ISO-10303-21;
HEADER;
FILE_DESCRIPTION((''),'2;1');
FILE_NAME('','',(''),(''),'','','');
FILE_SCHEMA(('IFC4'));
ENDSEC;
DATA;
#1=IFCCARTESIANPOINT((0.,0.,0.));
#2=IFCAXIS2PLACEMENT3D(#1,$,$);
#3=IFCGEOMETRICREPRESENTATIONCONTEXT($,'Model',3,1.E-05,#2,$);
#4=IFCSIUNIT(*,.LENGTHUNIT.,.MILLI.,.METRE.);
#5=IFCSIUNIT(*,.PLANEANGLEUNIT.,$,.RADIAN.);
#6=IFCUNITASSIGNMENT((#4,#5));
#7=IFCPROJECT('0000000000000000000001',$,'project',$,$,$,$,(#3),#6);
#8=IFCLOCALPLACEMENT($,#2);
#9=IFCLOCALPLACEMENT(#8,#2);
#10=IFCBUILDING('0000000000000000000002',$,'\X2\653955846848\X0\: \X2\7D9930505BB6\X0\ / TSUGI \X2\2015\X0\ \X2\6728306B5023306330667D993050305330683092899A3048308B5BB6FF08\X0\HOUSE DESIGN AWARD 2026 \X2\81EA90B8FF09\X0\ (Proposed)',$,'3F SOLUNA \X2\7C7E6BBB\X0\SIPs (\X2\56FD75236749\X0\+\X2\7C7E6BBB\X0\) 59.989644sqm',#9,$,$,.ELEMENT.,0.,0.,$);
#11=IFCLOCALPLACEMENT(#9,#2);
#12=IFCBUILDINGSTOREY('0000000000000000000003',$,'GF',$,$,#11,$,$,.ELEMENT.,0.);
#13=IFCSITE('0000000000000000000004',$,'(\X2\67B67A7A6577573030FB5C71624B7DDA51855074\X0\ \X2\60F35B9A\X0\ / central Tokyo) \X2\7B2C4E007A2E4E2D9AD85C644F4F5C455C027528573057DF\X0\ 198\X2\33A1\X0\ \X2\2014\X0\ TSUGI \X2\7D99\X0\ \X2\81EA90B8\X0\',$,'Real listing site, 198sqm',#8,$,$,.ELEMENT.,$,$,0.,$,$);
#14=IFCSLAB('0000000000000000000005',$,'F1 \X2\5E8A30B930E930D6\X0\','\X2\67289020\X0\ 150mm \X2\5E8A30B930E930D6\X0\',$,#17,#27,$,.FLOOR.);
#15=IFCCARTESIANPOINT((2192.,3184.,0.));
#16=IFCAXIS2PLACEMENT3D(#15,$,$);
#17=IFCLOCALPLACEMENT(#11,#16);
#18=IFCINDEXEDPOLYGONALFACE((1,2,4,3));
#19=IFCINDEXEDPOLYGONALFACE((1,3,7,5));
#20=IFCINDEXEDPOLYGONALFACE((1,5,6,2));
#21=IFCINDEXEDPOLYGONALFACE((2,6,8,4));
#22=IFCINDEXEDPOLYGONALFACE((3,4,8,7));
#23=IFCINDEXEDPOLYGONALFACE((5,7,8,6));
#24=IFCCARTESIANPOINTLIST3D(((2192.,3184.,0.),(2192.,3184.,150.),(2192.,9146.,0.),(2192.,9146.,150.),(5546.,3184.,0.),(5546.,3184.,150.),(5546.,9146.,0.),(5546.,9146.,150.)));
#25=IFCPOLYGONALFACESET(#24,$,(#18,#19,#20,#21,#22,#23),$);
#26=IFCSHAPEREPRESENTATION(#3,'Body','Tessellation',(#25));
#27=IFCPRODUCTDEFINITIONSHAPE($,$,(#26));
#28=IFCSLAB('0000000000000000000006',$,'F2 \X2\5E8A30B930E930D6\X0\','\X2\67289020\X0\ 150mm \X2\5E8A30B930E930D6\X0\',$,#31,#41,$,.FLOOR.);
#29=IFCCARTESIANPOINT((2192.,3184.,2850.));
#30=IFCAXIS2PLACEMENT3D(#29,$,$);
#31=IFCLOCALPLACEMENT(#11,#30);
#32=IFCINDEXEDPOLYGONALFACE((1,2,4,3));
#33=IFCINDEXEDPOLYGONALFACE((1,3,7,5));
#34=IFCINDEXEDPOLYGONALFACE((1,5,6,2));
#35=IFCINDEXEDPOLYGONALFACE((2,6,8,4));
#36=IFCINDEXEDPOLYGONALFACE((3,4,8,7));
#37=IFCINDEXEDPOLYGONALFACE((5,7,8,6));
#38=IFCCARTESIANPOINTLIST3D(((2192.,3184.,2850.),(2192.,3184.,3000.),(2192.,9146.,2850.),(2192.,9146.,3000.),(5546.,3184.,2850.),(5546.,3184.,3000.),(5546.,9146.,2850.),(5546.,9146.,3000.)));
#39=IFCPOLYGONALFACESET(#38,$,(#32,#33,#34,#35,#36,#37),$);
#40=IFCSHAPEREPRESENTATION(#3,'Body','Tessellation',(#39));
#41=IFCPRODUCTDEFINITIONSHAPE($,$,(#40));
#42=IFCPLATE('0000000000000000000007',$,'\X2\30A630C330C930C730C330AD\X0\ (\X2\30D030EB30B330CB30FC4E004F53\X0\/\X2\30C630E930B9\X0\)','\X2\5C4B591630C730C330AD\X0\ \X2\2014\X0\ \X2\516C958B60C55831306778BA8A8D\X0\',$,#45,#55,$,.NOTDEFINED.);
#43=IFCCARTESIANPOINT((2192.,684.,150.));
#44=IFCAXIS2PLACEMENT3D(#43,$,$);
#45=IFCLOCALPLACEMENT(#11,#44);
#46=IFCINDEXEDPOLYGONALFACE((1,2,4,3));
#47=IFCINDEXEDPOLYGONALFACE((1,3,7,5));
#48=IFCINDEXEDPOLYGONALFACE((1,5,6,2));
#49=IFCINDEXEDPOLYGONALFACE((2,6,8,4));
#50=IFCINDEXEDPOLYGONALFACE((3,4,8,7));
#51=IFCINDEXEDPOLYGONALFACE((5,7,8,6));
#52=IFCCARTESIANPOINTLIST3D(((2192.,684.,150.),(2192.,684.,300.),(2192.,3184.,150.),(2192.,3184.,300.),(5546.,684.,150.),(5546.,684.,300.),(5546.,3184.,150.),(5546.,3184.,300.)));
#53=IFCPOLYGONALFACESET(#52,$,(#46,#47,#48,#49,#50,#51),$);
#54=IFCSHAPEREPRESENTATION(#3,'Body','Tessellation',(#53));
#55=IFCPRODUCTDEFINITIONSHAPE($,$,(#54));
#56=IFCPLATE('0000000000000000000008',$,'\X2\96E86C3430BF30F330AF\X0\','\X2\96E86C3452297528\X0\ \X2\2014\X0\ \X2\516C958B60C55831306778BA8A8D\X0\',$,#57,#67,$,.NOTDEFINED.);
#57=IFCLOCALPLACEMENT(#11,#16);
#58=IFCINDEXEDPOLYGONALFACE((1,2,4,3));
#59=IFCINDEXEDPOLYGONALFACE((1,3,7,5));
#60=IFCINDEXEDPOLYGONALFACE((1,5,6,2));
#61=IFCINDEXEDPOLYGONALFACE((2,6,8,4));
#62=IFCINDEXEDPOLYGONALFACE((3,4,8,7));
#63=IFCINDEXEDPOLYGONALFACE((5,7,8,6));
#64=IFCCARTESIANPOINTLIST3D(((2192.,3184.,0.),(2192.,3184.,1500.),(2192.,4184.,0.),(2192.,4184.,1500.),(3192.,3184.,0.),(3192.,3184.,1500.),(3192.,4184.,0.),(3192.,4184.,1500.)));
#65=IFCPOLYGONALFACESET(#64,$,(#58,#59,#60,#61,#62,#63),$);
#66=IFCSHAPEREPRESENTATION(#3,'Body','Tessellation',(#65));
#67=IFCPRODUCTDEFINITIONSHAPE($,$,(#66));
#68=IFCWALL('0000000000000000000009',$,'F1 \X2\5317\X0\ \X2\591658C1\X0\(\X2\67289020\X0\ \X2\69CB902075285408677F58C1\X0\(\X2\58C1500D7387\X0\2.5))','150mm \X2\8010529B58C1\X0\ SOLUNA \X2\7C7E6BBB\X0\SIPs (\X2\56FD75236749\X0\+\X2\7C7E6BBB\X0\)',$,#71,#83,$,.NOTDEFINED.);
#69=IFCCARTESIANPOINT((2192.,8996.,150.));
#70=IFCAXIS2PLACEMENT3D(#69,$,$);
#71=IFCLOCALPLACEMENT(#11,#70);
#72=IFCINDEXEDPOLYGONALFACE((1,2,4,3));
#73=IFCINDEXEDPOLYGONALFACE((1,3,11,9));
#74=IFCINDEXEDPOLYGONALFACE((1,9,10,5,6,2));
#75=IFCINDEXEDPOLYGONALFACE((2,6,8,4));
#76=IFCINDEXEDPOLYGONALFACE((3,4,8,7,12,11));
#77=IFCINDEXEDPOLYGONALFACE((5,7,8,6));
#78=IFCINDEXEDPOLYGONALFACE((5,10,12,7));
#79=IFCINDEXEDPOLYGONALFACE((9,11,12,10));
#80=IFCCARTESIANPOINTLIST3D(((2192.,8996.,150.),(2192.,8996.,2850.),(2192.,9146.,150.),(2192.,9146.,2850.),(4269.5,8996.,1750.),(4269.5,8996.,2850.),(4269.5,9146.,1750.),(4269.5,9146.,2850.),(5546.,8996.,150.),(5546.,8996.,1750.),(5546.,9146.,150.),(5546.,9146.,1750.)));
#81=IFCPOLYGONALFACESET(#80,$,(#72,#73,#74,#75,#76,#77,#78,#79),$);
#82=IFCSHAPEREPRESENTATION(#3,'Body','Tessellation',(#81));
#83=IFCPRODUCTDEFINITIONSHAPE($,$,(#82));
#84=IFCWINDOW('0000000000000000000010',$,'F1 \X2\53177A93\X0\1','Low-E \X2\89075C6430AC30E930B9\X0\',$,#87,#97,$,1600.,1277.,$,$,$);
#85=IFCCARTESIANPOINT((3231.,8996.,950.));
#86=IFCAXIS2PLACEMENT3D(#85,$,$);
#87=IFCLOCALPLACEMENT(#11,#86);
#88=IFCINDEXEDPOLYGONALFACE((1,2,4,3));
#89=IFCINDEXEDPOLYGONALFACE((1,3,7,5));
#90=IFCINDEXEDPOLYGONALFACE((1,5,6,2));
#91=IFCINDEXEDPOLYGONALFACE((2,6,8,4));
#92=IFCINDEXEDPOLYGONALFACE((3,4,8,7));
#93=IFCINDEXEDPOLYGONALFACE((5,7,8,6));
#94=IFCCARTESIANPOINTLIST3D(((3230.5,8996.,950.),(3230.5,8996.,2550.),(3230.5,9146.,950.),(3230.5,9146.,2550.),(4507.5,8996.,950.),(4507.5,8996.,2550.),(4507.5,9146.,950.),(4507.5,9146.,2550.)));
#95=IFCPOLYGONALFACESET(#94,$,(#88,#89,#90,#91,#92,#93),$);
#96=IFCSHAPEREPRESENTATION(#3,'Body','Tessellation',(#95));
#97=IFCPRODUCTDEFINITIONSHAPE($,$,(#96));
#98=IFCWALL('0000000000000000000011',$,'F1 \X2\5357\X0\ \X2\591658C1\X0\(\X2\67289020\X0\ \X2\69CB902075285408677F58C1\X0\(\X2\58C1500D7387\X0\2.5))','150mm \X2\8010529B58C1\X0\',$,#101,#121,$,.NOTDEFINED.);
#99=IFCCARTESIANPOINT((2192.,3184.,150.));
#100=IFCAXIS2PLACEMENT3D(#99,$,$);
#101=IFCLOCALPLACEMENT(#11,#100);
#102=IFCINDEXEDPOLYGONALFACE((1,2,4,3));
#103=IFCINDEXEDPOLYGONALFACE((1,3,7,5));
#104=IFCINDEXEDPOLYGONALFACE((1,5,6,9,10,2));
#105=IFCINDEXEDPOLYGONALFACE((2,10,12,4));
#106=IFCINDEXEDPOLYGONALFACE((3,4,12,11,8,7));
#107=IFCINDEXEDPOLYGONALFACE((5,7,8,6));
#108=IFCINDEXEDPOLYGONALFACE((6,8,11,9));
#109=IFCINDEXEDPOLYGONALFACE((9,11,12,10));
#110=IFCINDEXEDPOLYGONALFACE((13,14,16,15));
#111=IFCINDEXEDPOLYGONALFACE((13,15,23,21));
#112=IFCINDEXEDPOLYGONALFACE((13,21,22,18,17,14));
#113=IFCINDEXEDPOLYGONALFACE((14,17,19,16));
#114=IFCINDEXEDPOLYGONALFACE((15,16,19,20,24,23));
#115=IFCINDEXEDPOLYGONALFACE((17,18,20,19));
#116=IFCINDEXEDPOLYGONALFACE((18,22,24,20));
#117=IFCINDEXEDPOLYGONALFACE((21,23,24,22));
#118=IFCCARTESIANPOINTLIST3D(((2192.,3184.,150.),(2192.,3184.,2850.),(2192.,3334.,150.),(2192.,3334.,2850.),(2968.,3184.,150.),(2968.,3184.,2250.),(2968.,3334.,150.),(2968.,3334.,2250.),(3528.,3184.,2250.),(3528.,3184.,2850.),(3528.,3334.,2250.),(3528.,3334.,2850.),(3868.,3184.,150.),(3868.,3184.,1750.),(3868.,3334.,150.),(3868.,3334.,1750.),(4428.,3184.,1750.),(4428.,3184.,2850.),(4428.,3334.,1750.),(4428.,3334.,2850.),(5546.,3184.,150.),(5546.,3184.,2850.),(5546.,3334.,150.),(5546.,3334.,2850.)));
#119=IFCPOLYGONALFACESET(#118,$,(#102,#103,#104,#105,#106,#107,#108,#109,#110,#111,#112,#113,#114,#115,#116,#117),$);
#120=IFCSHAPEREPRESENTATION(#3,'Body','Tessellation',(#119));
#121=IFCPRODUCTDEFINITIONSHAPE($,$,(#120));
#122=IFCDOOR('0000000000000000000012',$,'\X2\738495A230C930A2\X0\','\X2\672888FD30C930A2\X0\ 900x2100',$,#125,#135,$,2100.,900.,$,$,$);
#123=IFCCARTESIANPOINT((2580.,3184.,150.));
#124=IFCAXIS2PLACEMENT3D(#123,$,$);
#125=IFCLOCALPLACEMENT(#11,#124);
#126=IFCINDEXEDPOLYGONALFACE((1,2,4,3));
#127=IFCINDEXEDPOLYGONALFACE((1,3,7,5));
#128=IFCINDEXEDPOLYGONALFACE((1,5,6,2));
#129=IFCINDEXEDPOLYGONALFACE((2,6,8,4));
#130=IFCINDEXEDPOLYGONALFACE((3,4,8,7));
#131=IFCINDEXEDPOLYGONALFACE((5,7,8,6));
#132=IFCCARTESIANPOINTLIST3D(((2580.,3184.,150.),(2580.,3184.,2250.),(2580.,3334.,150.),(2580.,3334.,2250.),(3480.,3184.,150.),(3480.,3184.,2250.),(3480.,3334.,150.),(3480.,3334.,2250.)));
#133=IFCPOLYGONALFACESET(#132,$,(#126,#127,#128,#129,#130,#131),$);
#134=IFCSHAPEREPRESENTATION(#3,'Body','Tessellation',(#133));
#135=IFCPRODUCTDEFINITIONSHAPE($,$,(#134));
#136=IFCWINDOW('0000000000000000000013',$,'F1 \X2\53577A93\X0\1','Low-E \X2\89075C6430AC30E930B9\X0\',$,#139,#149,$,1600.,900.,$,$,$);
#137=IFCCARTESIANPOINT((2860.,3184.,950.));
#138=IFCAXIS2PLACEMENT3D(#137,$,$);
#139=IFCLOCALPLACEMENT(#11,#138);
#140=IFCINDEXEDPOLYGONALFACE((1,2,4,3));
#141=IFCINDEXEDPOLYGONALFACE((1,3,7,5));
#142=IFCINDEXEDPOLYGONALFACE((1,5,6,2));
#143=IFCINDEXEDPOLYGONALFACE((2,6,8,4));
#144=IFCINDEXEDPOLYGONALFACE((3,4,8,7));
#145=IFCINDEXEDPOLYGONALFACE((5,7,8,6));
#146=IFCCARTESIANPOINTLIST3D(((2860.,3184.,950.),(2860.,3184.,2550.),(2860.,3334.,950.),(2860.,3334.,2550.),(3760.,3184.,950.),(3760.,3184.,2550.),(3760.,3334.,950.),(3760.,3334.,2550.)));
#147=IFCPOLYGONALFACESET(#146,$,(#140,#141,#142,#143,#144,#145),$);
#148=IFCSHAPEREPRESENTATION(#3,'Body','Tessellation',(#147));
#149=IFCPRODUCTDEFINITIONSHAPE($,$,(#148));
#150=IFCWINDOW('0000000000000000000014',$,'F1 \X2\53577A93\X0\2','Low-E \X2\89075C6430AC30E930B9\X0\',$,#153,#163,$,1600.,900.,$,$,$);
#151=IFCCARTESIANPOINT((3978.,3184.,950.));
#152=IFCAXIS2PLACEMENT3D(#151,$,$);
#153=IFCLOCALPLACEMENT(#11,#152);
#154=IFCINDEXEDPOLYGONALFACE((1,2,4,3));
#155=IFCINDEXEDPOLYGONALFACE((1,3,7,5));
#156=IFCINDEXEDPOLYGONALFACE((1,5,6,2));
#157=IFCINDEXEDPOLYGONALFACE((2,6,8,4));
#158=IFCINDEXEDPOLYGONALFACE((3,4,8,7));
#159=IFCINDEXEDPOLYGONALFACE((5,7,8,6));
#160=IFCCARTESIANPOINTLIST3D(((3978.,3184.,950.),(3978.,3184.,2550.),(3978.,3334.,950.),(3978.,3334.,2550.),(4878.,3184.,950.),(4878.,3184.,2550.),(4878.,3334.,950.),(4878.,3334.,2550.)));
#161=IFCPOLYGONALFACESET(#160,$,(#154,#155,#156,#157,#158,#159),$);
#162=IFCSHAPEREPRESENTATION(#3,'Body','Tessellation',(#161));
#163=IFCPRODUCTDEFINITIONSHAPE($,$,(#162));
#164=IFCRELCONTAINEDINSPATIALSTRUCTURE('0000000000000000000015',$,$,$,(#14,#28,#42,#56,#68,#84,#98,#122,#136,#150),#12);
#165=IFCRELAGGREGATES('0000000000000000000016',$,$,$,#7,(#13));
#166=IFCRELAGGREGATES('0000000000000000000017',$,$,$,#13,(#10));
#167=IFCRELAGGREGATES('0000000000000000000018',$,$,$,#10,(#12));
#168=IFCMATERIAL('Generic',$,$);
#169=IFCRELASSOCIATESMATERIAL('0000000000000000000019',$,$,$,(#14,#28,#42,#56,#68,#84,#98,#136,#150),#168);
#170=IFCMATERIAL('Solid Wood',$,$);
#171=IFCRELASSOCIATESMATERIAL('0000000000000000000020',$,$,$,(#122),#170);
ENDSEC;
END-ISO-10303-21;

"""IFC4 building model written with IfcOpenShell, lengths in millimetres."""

from ifc_helpers import new_model, si_unit, frame, frame_2d, origin, place, context, project, spatial, rectangle, extrude, material, element, fill, save


model = new_model("IFC4")

# Units and contexts
model_context = context("Model", 3, precision=1e-05, world=origin())
ifc_project = project(units=[si_unit("LENGTHUNIT", "METRE", prefix="MILLI"), si_unit("PLANEANGLEUNIT", "RADIAN")], contexts=[model_context])

# Site, building, storey
site_placement = place(None, origin())
site = spatial("IfcSite", under=ifc_project, at=site_placement, Name="(架空敷地・山手線内側 想定 / central Tokyo) 第一種中高層住居専用地域 198㎡ — TSUGI 継 自邸", ObjectType="Real listing site, 198sqm", CompositionType="ELEMENT", RefElevation=0.0)
building_placement = place(site_placement, origin())
building = spatial("IfcBuilding", under=site, at=building_placement, Name="改善案: 継ぐ家 / TSUGI ― 木に倣って継ぐことを覚える家（HOUSE DESIGN AWARD 2026 自邸） (Proposed)", ObjectType="3F SOLUNA 籾殻SIPs (国産杉+籾殻) 59.989644sqm", CompositionType="ELEMENT", ElevationOfRefHeight=0.0, ElevationOfTerrain=0.0)
storey_placement = place(building_placement, origin())
storey = spatial("IfcBuildingStorey", under=building, at=storey_placement, Name="GF", CompositionType="ELEMENT", Elevation=0.0)

# Slabs
ifc_material_1 = material(Name="Generic")
slab_1_placement = place(storey_placement, frame((2192.0, 3184.0, 0.0)))
element("IfcSlab", 1, at=slab_1_placement, inside=storey, material=ifc_material_1, Name="F1 床スラブ", Description="木造 150mm 床スラブ", PredefinedType="FLOOR", context=model_context, shape_type="SweptSolid", body=[
    extrude(rectangle(XDim=3354.0, YDim=5962.0, at=frame_2d((1677.0, 2981.0))), frame((2192.0, 3184.0, 0.0)), (0.0, 0.0, 1.0), 150.0),
])
slab_2_placement = place(storey_placement, frame((2192.0, 3184.0, 2850.0)))
element("IfcSlab", 2, at=slab_2_placement, inside=storey, material=ifc_material_1, Name="F2 床スラブ", Description="木造 150mm 床スラブ", PredefinedType="FLOOR", context=model_context, shape_type="SweptSolid", body=[
    extrude(rectangle(XDim=3354.0, YDim=5962.0, at=frame_2d((1677.0, 2981.0))), frame((2192.0, 3184.0, 2850.0)), (0.0, 0.0, 1.0), 150.0),
])

# Plates
plate_1_placement = place(storey_placement, frame((2192.0, 684.0, 150.0)))
element("IfcPlate", 3, at=plate_1_placement, inside=storey, material=ifc_material_1, Name="ウッドデッキ (バルコニー一体/テラス)", Description="屋外デッキ — 公開情報で確認", PredefinedType="NOTDEFINED", context=model_context, shape_type="SweptSolid", body=[
    extrude(rectangle(XDim=3354.0, YDim=2500.0, at=frame_2d((1677.0, 1250.0))), frame((2192.0, 684.0, 150.0)), (0.0, 0.0, 1.0), 150.0),
])
plate_2_placement = place(storey_placement, frame((2192.0, 3184.0, 0.0)))
element("IfcPlate", 4, at=plate_2_placement, inside=storey, material=ifc_material_1, Name="雨水タンク", Description="雨水利用 — 公開情報で確認", PredefinedType="NOTDEFINED", context=model_context, shape_type="SweptSolid", body=[
    extrude(rectangle(XDim=1000.0, YDim=1000.0, at=frame_2d((500.0, 500.0))), frame((2192.0, 3184.0, 0.0)), (0.0, 0.0, 1.0), 1500.0),
])

# Wall, opening, window
wall_1_placement = place(storey_placement, frame((2192.0, 8996.0, 150.0)))
wall_1 = element("IfcWall", 5, at=wall_1_placement, inside=storey, material=ifc_material_1, Name="F1 北 外壁(木造 構造用合板壁(壁倍率2.5))", Description="150mm 耐力壁 SOLUNA 籾殻SIPs (国産杉+籾殻)", PredefinedType="NOTDEFINED", context=model_context, shape_type="SweptSolid", body=[
    extrude(rectangle(XDim=3354.0, YDim=150.0, at=frame_2d((1677.0, 75.0))), frame((2192.0, 8996.0, 150.0)), (0.0, 0.0, 1.0), 2700.0),
])
opening_1_placement = place(storey_placement, frame((3231.0, 8996.0, 950.0)))
opening_1 = element("IfcOpeningElement", 6, at=opening_1_placement, cuts=wall_1, PredefinedType="NOTDEFINED", context=model_context, shape_type="SweptSolid", body=[
    extrude(rectangle(XDim=1277.0, YDim=150.0, at=frame_2d((638.0, 75.0))), frame((3231.0, 8996.0, 950.0)), (0.0, 0.0, 1.0), 1600.0),
])
window_1_placement = place(storey_placement, frame((3231.0, 8996.0, 950.0)))
window_1 = element("IfcWindow", 7, at=window_1_placement, inside=storey, material=ifc_material_1, Name="F1 北窓1", Description="Low-E 複層ガラス", OverallHeight=1600.0, OverallWidth=1277.0, context=model_context, shape_type="SweptSolid", body=[
    extrude(rectangle(XDim=1277.0, YDim=150.0, at=frame_2d((638.0, 75.0))), frame((3231.0, 8996.0, 950.0)), (0.0, 0.0, 1.0), 1600.0),
])
fill(opening_1, window_1)

# Wall, openings, door, windows
wall_2_placement = place(storey_placement, frame((2192.0, 3184.0, 150.0)))
wall_2 = element("IfcWall", 8, at=wall_2_placement, inside=storey, material=ifc_material_1, Name="F1 南 外壁(木造 構造用合板壁(壁倍率2.5))", Description="150mm 耐力壁", PredefinedType="NOTDEFINED", context=model_context, shape_type="SweptSolid", body=[
    extrude(rectangle(XDim=3354.0, YDim=150.0, at=frame_2d((1677.0, 75.0))), frame((2192.0, 3184.0, 150.0)), (0.0, 0.0, 1.0), 2700.0),
])
opening_2_placement = place(storey_placement, frame((2580.0, 3184.0, 150.0)))
opening_2 = element("IfcOpeningElement", 9, at=opening_2_placement, cuts=wall_2, PredefinedType="NOTDEFINED", context=model_context, shape_type="SweptSolid", body=[
    extrude(rectangle(XDim=900.0, YDim=150.0, at=frame_2d((450.0, 75.0))), frame((2580.0, 3184.0, 150.0)), (0.0, 0.0, 1.0), 2100.0),
])
opening_3_placement = place(storey_placement, frame((2860.0, 3184.0, 950.0)))
opening_3 = element("IfcOpeningElement", 10, at=opening_3_placement, cuts=wall_2, PredefinedType="NOTDEFINED", context=model_context, shape_type="SweptSolid", body=[
    extrude(rectangle(XDim=900.0, YDim=150.0, at=frame_2d((450.0, 75.0))), frame((2860.0, 3184.0, 950.0)), (0.0, 0.0, 1.0), 1600.0),
])
opening_4_placement = place(storey_placement, frame((3978.0, 3184.0, 950.0)))
opening_4 = element("IfcOpeningElement", 11, at=opening_4_placement, cuts=wall_2, PredefinedType="NOTDEFINED", context=model_context, shape_type="SweptSolid", body=[
    extrude(rectangle(XDim=900.0, YDim=150.0, at=frame_2d((450.0, 75.0))), frame((3978.0, 3184.0, 950.0)), (0.0, 0.0, 1.0), 1600.0),
])
ifc_material_2 = material(Name="Solid Wood")
door_placement = place(storey_placement, frame((2580.0, 3184.0, 150.0)))
door = element("IfcDoor", 12, at=door_placement, inside=storey, material=ifc_material_2, Name="玄関ドア", Description="木製ドア 900x2100", OverallHeight=2100.0, OverallWidth=900.0, context=model_context, shape_type="SweptSolid", body=[
    extrude(rectangle(XDim=900.0, YDim=150.0, at=frame_2d((450.0, 75.0))), frame((2580.0, 3184.0, 150.0)), (0.0, 0.0, 1.0), 2100.0),
])
fill(opening_2, door)
window_2_placement = place(storey_placement, frame((2860.0, 3184.0, 950.0)))
window_2 = element("IfcWindow", 13, at=window_2_placement, inside=storey, material=ifc_material_1, Name="F1 南窓1", Description="Low-E 複層ガラス", OverallHeight=1600.0, OverallWidth=900.0, context=model_context, shape_type="SweptSolid", body=[
    extrude(rectangle(XDim=900.0, YDim=150.0, at=frame_2d((450.0, 75.0))), frame((2860.0, 3184.0, 950.0)), (0.0, 0.0, 1.0), 1600.0),
])
fill(opening_3, window_2)
window_3_placement = place(storey_placement, frame((3978.0, 3184.0, 950.0)))
window_3 = element("IfcWindow", 14, at=window_3_placement, inside=storey, material=ifc_material_1, Name="F1 南窓2", Description="Low-E 複層ガラス", OverallHeight=1600.0, OverallWidth=900.0, context=model_context, shape_type="SweptSolid", body=[
    extrude(rectangle(XDim=900.0, YDim=150.0, at=frame_2d((450.0, 75.0))), frame((3978.0, 3184.0, 950.0)), (0.0, 0.0, 1.0), 1600.0),
])
fill(opening_4, window_3)

save(model, "model.ifc")
